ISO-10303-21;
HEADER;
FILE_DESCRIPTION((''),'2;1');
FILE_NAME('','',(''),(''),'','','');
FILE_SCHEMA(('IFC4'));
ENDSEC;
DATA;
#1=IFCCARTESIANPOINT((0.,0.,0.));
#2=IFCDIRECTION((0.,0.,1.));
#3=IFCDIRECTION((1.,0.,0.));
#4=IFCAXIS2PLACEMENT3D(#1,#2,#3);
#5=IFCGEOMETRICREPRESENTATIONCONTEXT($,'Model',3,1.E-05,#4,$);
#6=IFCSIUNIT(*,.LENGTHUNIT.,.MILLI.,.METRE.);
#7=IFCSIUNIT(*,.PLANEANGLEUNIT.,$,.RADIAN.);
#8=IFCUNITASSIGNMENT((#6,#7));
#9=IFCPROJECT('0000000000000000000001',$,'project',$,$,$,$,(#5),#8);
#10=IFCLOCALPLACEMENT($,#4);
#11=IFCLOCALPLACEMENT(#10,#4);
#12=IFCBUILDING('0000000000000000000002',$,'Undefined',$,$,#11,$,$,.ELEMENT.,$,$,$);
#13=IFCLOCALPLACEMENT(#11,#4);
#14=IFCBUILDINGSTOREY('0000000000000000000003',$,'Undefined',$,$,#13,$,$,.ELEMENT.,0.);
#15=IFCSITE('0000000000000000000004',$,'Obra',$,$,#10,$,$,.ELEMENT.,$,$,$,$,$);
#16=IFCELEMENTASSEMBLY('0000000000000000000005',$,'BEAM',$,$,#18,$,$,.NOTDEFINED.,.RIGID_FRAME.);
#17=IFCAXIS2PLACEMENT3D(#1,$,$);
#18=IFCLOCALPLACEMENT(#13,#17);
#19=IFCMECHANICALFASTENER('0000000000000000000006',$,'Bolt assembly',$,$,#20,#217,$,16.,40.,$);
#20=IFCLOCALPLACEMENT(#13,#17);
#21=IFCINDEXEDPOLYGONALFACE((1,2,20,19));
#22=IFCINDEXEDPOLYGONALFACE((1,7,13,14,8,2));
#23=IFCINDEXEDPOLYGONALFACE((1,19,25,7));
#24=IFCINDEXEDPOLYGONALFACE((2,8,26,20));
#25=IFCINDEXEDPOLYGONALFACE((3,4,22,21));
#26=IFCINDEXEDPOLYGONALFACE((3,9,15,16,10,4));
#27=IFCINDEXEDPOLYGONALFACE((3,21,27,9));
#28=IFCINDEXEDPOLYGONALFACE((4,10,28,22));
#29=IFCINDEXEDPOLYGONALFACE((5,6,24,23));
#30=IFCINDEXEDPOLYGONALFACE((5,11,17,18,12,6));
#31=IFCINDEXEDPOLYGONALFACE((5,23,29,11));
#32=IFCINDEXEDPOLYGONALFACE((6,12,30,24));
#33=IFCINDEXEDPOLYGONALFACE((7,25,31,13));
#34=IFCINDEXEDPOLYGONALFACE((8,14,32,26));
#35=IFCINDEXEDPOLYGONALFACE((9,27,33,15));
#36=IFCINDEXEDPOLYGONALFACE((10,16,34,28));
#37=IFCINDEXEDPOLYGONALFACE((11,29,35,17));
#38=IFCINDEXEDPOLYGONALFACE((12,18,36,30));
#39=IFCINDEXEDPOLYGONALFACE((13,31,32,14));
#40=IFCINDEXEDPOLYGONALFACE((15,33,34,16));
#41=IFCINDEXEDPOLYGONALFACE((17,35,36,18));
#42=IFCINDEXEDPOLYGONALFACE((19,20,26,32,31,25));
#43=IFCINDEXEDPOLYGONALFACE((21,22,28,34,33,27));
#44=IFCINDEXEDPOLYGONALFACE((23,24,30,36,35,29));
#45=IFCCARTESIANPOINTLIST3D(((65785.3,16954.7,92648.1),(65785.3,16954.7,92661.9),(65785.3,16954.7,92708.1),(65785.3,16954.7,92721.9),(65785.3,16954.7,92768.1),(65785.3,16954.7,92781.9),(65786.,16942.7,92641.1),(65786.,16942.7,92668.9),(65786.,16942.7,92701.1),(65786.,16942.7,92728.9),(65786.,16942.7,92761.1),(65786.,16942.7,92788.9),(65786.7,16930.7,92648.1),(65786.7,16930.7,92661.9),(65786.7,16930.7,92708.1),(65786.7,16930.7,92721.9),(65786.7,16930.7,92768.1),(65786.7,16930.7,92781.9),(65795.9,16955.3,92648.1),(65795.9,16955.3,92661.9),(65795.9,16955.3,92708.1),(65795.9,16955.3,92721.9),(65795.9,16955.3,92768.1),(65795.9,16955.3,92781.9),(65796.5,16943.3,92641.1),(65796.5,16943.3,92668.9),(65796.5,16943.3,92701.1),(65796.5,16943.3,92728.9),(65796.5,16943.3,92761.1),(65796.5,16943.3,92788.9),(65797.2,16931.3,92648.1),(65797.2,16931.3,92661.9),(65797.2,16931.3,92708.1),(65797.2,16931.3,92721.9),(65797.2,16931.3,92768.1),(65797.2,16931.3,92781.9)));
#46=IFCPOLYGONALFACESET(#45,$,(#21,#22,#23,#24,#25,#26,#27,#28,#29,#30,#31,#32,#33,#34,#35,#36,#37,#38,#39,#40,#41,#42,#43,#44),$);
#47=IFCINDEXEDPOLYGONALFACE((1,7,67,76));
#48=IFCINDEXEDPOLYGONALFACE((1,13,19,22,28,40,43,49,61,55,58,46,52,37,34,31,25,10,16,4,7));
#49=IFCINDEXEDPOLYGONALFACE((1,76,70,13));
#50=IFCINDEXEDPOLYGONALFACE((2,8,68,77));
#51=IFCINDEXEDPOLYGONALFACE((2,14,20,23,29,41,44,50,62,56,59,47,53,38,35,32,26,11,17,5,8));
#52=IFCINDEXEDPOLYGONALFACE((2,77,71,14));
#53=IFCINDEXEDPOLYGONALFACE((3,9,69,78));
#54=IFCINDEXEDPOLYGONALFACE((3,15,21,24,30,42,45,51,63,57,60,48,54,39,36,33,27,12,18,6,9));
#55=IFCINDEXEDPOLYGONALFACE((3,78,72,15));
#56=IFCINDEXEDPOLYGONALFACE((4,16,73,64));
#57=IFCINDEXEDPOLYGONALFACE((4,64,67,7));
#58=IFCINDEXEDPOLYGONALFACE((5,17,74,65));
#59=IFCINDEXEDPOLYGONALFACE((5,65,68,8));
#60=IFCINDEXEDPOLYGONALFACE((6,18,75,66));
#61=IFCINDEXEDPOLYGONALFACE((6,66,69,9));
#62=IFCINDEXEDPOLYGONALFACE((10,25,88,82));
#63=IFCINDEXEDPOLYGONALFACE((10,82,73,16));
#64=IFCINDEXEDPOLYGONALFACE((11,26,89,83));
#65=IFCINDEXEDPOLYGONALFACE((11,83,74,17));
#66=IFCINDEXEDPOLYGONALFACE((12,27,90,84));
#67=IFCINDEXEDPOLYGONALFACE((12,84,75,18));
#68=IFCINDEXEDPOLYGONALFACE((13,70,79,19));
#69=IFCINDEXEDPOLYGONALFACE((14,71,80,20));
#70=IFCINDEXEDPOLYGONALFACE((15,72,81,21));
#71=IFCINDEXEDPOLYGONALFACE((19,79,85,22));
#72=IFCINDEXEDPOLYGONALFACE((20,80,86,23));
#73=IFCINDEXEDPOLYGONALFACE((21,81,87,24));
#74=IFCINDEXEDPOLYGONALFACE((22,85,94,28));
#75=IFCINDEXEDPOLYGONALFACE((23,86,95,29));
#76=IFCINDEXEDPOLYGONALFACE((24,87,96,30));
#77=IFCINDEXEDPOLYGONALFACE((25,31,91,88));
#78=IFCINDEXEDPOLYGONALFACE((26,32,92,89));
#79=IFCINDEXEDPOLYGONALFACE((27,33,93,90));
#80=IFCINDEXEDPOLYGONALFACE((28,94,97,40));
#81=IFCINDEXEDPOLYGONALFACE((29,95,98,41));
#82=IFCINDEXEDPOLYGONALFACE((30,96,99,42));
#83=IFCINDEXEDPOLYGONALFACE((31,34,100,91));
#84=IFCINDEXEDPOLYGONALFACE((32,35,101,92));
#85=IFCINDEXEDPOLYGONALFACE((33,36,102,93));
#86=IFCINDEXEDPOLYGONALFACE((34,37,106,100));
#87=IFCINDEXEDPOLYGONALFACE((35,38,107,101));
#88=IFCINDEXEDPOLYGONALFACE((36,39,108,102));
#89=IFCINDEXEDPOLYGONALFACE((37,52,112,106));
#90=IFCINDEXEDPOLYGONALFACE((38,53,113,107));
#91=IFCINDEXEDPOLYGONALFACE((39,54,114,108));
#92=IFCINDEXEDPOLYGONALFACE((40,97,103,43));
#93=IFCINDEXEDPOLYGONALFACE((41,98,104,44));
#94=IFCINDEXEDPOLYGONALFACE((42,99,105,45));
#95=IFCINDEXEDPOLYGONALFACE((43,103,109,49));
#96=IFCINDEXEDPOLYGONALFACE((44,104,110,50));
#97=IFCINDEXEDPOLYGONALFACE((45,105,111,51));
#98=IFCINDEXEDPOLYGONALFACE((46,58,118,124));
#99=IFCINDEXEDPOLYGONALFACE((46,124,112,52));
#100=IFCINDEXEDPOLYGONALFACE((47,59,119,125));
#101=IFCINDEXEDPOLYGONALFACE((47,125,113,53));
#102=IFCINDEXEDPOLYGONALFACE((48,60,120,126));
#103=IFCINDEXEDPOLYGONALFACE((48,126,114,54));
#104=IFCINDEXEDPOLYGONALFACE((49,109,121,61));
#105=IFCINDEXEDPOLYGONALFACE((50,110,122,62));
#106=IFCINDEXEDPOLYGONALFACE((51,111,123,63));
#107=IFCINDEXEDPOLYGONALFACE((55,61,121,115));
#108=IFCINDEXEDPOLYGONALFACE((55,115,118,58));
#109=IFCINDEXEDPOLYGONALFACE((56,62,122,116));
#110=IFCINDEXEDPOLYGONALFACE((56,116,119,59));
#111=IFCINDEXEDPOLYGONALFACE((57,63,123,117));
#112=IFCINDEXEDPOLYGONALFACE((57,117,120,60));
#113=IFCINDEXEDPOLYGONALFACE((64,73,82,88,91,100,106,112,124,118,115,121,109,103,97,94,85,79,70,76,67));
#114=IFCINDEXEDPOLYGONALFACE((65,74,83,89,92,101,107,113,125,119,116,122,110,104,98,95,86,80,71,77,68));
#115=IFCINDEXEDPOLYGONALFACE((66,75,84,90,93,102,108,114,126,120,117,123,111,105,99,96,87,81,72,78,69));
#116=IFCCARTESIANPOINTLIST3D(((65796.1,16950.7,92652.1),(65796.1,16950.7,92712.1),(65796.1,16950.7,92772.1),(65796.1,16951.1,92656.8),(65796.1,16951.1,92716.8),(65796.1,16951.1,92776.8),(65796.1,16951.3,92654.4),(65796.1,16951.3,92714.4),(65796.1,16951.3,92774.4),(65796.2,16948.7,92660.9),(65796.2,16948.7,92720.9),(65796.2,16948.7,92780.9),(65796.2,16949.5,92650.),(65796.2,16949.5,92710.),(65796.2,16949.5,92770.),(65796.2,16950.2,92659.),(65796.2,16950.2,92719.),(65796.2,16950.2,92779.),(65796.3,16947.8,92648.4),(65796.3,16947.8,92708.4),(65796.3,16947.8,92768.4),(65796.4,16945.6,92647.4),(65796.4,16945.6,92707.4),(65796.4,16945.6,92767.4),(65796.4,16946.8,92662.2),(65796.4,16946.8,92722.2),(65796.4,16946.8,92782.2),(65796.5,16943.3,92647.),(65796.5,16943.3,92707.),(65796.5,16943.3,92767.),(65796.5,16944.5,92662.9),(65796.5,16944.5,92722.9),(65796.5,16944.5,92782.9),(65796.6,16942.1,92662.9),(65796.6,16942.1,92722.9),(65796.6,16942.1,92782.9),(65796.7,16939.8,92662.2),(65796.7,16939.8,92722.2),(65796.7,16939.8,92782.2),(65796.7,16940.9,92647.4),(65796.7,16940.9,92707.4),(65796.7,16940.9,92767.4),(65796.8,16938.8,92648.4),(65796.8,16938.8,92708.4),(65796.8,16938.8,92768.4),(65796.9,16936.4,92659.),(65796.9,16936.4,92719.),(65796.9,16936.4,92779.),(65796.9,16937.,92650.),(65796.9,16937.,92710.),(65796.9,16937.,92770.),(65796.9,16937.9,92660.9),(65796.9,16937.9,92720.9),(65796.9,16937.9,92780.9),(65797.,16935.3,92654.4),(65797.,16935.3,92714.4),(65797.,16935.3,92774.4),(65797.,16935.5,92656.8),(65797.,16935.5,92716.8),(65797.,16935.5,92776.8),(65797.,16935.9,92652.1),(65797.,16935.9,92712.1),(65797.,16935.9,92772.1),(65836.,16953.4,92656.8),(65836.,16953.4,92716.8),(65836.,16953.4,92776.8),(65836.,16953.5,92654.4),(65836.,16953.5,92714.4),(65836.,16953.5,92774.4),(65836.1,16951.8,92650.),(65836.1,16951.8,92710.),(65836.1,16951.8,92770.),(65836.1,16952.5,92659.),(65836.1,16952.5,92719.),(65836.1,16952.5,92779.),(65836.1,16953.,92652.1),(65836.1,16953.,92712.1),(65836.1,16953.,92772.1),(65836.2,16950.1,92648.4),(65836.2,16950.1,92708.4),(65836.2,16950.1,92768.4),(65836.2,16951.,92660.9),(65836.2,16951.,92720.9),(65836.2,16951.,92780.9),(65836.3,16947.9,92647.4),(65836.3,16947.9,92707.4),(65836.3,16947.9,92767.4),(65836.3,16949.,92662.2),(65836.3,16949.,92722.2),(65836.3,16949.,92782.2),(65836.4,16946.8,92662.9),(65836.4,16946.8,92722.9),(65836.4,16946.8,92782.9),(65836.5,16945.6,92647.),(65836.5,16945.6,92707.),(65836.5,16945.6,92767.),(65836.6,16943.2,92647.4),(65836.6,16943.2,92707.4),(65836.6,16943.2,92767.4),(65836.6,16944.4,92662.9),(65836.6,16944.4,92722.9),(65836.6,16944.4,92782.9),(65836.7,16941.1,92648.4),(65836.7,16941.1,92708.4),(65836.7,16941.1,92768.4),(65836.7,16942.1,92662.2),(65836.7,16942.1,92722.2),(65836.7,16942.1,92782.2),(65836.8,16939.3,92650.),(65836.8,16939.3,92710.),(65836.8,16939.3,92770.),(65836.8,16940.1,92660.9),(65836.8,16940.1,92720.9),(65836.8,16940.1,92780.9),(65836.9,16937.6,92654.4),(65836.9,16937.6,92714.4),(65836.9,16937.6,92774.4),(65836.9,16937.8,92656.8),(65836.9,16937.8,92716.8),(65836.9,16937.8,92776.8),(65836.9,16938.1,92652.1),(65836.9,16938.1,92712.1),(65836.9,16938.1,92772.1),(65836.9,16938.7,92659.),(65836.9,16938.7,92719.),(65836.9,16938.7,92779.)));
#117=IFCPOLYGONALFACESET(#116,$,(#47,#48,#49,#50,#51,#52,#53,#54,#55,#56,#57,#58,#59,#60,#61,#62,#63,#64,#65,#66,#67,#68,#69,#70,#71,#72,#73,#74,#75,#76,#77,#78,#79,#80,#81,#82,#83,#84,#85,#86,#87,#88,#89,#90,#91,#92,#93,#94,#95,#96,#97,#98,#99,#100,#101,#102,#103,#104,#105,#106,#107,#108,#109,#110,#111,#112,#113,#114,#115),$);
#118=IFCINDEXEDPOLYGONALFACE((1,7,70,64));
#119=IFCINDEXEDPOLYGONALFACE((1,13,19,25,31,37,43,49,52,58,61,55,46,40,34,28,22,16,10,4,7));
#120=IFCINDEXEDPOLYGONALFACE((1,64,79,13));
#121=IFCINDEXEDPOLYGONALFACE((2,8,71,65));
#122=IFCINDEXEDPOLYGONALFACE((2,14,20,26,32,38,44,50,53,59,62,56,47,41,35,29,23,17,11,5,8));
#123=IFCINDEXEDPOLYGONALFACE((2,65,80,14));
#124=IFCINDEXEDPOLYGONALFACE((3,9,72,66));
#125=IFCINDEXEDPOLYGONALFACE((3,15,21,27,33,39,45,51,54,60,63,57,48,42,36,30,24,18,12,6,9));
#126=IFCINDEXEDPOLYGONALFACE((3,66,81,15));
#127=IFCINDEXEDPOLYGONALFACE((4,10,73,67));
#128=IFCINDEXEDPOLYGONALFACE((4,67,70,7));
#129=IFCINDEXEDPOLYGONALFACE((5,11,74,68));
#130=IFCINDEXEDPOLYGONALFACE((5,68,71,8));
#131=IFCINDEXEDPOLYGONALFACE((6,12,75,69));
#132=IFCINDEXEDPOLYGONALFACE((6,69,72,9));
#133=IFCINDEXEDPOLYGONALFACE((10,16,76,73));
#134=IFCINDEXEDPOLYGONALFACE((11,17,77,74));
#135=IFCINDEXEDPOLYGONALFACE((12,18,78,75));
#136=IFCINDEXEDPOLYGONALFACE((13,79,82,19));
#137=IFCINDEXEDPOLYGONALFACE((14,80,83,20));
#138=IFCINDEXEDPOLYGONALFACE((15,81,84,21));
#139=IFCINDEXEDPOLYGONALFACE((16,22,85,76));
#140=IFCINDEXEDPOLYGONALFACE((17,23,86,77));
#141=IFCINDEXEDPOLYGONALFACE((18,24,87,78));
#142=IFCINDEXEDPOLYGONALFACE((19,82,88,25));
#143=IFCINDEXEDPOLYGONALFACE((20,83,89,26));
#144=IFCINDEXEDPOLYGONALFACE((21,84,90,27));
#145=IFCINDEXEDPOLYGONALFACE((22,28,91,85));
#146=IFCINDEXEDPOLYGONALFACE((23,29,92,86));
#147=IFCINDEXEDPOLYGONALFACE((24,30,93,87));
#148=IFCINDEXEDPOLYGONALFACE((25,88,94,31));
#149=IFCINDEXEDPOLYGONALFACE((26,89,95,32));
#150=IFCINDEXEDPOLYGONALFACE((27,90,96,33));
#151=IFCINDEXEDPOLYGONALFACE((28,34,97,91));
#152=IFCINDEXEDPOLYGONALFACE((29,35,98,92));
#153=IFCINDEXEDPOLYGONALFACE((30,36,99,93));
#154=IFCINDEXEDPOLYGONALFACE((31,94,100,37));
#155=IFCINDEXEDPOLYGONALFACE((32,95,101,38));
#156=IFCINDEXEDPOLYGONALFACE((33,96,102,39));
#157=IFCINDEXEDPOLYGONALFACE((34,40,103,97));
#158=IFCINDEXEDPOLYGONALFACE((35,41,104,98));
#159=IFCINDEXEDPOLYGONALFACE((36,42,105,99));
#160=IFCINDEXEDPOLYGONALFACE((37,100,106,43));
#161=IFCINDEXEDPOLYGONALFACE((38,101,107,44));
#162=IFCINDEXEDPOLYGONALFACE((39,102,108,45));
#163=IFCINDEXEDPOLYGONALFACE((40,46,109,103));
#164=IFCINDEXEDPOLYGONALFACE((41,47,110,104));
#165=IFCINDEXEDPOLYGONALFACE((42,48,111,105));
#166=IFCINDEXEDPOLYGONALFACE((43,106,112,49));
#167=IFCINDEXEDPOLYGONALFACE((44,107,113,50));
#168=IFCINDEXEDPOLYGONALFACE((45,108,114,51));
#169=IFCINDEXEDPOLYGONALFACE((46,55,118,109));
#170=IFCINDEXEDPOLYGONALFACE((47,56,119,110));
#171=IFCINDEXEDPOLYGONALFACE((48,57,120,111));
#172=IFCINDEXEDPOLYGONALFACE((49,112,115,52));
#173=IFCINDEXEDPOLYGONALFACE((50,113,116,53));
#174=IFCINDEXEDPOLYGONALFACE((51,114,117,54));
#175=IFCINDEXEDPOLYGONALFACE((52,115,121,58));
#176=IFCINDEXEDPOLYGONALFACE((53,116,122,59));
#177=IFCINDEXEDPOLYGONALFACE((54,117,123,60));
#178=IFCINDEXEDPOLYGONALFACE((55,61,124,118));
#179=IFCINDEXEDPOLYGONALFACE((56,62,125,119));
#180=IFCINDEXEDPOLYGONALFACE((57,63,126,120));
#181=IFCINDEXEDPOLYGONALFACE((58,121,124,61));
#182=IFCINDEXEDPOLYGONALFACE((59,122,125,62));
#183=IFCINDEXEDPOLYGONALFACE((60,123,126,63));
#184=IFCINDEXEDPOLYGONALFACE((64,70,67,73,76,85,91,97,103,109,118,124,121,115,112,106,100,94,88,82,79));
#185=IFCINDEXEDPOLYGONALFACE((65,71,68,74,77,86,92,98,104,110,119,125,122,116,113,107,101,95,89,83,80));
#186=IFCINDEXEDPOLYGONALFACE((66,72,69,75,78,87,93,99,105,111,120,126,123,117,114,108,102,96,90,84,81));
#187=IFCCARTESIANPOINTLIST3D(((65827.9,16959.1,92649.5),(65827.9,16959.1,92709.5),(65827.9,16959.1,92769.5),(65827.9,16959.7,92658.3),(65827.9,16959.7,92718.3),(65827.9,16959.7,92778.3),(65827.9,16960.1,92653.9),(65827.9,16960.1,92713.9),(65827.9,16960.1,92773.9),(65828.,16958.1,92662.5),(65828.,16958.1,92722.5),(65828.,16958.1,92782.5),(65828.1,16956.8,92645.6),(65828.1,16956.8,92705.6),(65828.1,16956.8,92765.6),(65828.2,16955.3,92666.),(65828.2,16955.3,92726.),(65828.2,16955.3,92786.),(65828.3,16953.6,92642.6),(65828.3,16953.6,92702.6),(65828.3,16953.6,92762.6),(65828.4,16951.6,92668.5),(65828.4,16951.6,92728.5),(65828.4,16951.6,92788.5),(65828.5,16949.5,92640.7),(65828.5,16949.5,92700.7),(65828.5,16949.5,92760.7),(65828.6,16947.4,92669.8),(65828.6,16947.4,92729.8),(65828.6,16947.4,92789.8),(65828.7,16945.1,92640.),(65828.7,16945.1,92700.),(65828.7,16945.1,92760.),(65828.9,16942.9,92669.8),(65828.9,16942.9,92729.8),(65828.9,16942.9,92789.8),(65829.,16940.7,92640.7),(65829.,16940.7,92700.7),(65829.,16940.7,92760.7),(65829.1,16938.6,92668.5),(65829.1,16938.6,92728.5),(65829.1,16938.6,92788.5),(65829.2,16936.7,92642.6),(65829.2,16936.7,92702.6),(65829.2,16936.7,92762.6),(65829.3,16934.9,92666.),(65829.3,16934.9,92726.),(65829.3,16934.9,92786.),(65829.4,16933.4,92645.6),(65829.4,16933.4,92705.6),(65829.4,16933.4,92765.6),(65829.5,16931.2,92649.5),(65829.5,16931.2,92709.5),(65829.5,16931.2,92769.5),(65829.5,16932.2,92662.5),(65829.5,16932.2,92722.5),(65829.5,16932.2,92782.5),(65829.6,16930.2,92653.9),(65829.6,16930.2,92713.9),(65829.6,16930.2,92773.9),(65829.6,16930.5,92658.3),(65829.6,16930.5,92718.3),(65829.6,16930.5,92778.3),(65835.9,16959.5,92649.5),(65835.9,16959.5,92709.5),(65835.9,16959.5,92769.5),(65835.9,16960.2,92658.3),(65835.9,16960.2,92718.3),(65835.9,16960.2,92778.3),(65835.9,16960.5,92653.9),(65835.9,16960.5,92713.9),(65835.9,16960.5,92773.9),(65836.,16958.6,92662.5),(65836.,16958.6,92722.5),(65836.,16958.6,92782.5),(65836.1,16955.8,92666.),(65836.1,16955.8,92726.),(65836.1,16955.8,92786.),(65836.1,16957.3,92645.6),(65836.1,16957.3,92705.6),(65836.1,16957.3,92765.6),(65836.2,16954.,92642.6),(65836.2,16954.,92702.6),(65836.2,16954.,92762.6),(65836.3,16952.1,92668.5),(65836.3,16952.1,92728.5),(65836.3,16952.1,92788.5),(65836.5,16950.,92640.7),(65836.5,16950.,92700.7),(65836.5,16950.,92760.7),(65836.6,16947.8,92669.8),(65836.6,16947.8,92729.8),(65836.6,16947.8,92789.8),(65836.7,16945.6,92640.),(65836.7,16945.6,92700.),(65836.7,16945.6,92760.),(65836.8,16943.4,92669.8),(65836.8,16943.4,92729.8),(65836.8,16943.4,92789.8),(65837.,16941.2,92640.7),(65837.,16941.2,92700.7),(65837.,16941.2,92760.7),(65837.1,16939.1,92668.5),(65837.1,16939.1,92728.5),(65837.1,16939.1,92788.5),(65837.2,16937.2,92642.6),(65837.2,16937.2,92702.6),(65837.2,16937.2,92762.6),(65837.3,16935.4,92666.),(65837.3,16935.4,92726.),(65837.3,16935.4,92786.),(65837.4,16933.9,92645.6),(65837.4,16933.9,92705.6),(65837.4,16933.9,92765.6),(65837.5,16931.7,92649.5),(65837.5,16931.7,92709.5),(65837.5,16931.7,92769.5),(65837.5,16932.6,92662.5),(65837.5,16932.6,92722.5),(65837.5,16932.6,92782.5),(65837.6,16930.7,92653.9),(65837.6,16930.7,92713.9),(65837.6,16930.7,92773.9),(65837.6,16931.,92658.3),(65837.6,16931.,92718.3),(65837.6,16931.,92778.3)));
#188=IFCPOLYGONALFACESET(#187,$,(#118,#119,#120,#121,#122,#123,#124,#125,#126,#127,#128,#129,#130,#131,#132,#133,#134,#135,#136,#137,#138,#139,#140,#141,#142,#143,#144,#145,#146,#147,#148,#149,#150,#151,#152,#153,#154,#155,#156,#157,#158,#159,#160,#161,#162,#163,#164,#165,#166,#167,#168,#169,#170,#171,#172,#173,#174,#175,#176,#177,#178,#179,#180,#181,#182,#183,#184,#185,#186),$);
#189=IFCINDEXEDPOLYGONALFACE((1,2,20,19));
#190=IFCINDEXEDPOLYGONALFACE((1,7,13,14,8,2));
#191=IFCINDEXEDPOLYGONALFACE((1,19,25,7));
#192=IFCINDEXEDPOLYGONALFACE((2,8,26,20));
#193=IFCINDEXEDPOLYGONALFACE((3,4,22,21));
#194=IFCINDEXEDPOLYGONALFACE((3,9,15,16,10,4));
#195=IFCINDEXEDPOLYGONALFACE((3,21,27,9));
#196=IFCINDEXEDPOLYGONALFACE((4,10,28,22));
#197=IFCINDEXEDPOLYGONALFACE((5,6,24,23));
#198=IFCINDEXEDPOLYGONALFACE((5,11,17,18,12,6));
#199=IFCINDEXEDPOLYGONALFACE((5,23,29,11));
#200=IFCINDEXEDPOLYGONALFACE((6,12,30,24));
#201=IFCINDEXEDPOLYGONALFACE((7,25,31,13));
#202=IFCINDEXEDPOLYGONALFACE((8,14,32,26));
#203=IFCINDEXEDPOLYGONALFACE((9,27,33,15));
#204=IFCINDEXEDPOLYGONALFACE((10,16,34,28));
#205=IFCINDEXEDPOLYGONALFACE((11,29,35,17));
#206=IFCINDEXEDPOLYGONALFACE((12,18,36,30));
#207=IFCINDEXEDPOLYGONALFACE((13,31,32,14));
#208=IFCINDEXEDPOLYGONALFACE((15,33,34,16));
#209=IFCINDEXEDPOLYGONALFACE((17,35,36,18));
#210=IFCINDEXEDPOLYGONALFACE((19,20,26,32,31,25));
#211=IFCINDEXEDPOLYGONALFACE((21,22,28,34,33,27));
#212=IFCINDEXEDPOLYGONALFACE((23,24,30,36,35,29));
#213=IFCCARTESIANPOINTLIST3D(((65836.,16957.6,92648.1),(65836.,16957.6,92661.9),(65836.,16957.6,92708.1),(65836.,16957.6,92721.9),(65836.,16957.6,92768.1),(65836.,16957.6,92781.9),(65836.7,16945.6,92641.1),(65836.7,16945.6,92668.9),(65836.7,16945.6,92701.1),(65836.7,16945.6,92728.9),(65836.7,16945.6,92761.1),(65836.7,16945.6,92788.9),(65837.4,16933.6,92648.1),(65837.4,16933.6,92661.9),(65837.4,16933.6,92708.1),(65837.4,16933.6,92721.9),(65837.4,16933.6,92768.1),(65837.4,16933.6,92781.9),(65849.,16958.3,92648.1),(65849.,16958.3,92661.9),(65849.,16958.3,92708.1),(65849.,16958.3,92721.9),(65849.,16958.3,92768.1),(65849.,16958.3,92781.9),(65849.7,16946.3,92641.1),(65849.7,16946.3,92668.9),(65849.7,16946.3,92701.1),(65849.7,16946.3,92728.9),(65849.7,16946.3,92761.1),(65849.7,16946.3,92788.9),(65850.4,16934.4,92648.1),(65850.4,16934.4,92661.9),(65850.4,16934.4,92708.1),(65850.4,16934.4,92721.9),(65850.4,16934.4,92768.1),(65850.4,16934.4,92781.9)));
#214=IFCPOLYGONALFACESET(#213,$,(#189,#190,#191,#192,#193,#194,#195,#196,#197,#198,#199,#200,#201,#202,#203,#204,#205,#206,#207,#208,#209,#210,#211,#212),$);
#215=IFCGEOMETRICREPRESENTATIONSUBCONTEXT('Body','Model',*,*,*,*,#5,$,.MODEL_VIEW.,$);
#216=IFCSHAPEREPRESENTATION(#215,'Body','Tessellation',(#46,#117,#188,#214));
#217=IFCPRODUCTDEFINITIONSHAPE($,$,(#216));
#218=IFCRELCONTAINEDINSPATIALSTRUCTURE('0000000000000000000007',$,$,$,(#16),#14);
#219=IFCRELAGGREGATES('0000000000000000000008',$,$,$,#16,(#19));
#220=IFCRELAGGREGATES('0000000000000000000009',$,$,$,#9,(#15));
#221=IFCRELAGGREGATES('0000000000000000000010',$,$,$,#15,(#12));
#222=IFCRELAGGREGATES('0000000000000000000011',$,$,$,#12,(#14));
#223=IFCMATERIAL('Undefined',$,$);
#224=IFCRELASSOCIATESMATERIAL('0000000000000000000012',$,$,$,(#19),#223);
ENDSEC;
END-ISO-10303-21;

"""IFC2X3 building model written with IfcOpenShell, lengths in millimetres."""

from ifc_helpers import new_model, si_unit, frame, origin_with_axes, origin_2d_with_axis, place, context, subcontext, project, spatial, polyline, circle, outline, extrude, source, transform, mapped, material, element, aggregate, save


model = new_model("IFC2X3")

# Units and contexts
model_context = context("Model", 3, precision=1e-05, world=origin_with_axes())
body_context = subcontext(model_context, "Body", "Model", "MODEL_VIEW")
ifc_project = project(units=[si_unit("LENGTHUNIT", "METRE", prefix="MILLI"), si_unit("PLANEANGLEUNIT", "RADIAN")], contexts=[model_context])

# Site, building, storey
site_placement = place(None, origin_with_axes())
site = spatial("IfcSite", under=ifc_project, at=site_placement, Name="Obra", CompositionType="ELEMENT")
building_placement = place(site_placement, origin_with_axes())
building = spatial("IfcBuilding", under=site, at=building_placement, Name="Undefined", CompositionType="ELEMENT")
storey_placement = place(building_placement, origin_with_axes())
storey = spatial("IfcBuildingStorey", under=building, at=storey_placement, Name="Undefined", CompositionType="ELEMENT", Elevation=0.0)

# Shared definitions
ifc_material_1 = material(Name="Undefined")

# Element assembly, mechanical fastener
assembly_1_placement = place(storey_placement, origin_with_axes())
assembly_1 = element("IfcElementAssembly", 1, at=assembly_1_placement, inside=storey, Name="BEAM", AssemblyPlace="NOTDEFINED", PredefinedType="RIGID_FRAME")
shared_shape_1 = source(origin_with_axes(), body_context, "Body", "SweptSolid", [
    extrude(outline(polyline([(13.9, 0.0), (6.9, 12.0), (-6.9, 12.0), (-13.9, 0.0), (-6.9, -12.0), (6.9, -12.0), (13.9, 0.0)])), frame((0.0, -45.9, 0.0), z_axis=(0.0, 1.0, 0.0), x_axis=(1.0, 0.0, 0.0)), (0.0, 0.0, 1.0), 10.6),
    extrude(circle(Radius=8.0, at=origin_2d_with_axis()), frame((0.0, -35.3, 0.0), z_axis=(0.0, 1.0, 0.0), x_axis=(1.0, 0.0, 0.0)), (0.0, 0.0, 1.0), 40.0),
    extrude(circle(Radius=15.0, at=origin_2d_with_axis()), frame((0.0, -3.1, 0.0), z_axis=(0.0, 1.0, 0.0), x_axis=(1.0, 0.0, 0.0)), (0.0, 0.0, 1.0), 8.0),
    extrude(outline(polyline([(13.9, 0.0), (6.9, 12.0), (-6.9, 12.0), (-13.9, 0.0), (-6.9, -12.0), (6.9, -12.0), (13.9, 0.0)])), frame((0.0, 4.9, 0.0), z_axis=(0.0, 1.0, 0.0), x_axis=(1.0, 0.0, 0.0)), (0.0, 0.0, 1.0), 13.0),
])
mechanical_fastener_1_placement = place(assembly_1_placement, frame((65829.0, 16995.2, 92835.0), z_axis=(0.057107, -0.998368, 0.0), x_axis=(0.0, 0.0, -1.0)))
mechanical_fastener_1 = element("IfcMechanicalFastener", 2, at=mechanical_fastener_1_placement, material=ifc_material_1, Name="Bolt assembly", NominalDiameter=16.0, NominalLength=40.0, context=body_context, shape_type="MappedRepresentation", body=[
    mapped(shared_shape_1, transform((60.0, 0.0, 50.0))),
    mapped(shared_shape_1, transform((120.0, 0.0, 50.0))),
    mapped(shared_shape_1, transform((180.0, 0.0, 50.0))),
])
aggregate(assembly_1, [mechanical_fastener_1])

save(model, "model.ifc")
